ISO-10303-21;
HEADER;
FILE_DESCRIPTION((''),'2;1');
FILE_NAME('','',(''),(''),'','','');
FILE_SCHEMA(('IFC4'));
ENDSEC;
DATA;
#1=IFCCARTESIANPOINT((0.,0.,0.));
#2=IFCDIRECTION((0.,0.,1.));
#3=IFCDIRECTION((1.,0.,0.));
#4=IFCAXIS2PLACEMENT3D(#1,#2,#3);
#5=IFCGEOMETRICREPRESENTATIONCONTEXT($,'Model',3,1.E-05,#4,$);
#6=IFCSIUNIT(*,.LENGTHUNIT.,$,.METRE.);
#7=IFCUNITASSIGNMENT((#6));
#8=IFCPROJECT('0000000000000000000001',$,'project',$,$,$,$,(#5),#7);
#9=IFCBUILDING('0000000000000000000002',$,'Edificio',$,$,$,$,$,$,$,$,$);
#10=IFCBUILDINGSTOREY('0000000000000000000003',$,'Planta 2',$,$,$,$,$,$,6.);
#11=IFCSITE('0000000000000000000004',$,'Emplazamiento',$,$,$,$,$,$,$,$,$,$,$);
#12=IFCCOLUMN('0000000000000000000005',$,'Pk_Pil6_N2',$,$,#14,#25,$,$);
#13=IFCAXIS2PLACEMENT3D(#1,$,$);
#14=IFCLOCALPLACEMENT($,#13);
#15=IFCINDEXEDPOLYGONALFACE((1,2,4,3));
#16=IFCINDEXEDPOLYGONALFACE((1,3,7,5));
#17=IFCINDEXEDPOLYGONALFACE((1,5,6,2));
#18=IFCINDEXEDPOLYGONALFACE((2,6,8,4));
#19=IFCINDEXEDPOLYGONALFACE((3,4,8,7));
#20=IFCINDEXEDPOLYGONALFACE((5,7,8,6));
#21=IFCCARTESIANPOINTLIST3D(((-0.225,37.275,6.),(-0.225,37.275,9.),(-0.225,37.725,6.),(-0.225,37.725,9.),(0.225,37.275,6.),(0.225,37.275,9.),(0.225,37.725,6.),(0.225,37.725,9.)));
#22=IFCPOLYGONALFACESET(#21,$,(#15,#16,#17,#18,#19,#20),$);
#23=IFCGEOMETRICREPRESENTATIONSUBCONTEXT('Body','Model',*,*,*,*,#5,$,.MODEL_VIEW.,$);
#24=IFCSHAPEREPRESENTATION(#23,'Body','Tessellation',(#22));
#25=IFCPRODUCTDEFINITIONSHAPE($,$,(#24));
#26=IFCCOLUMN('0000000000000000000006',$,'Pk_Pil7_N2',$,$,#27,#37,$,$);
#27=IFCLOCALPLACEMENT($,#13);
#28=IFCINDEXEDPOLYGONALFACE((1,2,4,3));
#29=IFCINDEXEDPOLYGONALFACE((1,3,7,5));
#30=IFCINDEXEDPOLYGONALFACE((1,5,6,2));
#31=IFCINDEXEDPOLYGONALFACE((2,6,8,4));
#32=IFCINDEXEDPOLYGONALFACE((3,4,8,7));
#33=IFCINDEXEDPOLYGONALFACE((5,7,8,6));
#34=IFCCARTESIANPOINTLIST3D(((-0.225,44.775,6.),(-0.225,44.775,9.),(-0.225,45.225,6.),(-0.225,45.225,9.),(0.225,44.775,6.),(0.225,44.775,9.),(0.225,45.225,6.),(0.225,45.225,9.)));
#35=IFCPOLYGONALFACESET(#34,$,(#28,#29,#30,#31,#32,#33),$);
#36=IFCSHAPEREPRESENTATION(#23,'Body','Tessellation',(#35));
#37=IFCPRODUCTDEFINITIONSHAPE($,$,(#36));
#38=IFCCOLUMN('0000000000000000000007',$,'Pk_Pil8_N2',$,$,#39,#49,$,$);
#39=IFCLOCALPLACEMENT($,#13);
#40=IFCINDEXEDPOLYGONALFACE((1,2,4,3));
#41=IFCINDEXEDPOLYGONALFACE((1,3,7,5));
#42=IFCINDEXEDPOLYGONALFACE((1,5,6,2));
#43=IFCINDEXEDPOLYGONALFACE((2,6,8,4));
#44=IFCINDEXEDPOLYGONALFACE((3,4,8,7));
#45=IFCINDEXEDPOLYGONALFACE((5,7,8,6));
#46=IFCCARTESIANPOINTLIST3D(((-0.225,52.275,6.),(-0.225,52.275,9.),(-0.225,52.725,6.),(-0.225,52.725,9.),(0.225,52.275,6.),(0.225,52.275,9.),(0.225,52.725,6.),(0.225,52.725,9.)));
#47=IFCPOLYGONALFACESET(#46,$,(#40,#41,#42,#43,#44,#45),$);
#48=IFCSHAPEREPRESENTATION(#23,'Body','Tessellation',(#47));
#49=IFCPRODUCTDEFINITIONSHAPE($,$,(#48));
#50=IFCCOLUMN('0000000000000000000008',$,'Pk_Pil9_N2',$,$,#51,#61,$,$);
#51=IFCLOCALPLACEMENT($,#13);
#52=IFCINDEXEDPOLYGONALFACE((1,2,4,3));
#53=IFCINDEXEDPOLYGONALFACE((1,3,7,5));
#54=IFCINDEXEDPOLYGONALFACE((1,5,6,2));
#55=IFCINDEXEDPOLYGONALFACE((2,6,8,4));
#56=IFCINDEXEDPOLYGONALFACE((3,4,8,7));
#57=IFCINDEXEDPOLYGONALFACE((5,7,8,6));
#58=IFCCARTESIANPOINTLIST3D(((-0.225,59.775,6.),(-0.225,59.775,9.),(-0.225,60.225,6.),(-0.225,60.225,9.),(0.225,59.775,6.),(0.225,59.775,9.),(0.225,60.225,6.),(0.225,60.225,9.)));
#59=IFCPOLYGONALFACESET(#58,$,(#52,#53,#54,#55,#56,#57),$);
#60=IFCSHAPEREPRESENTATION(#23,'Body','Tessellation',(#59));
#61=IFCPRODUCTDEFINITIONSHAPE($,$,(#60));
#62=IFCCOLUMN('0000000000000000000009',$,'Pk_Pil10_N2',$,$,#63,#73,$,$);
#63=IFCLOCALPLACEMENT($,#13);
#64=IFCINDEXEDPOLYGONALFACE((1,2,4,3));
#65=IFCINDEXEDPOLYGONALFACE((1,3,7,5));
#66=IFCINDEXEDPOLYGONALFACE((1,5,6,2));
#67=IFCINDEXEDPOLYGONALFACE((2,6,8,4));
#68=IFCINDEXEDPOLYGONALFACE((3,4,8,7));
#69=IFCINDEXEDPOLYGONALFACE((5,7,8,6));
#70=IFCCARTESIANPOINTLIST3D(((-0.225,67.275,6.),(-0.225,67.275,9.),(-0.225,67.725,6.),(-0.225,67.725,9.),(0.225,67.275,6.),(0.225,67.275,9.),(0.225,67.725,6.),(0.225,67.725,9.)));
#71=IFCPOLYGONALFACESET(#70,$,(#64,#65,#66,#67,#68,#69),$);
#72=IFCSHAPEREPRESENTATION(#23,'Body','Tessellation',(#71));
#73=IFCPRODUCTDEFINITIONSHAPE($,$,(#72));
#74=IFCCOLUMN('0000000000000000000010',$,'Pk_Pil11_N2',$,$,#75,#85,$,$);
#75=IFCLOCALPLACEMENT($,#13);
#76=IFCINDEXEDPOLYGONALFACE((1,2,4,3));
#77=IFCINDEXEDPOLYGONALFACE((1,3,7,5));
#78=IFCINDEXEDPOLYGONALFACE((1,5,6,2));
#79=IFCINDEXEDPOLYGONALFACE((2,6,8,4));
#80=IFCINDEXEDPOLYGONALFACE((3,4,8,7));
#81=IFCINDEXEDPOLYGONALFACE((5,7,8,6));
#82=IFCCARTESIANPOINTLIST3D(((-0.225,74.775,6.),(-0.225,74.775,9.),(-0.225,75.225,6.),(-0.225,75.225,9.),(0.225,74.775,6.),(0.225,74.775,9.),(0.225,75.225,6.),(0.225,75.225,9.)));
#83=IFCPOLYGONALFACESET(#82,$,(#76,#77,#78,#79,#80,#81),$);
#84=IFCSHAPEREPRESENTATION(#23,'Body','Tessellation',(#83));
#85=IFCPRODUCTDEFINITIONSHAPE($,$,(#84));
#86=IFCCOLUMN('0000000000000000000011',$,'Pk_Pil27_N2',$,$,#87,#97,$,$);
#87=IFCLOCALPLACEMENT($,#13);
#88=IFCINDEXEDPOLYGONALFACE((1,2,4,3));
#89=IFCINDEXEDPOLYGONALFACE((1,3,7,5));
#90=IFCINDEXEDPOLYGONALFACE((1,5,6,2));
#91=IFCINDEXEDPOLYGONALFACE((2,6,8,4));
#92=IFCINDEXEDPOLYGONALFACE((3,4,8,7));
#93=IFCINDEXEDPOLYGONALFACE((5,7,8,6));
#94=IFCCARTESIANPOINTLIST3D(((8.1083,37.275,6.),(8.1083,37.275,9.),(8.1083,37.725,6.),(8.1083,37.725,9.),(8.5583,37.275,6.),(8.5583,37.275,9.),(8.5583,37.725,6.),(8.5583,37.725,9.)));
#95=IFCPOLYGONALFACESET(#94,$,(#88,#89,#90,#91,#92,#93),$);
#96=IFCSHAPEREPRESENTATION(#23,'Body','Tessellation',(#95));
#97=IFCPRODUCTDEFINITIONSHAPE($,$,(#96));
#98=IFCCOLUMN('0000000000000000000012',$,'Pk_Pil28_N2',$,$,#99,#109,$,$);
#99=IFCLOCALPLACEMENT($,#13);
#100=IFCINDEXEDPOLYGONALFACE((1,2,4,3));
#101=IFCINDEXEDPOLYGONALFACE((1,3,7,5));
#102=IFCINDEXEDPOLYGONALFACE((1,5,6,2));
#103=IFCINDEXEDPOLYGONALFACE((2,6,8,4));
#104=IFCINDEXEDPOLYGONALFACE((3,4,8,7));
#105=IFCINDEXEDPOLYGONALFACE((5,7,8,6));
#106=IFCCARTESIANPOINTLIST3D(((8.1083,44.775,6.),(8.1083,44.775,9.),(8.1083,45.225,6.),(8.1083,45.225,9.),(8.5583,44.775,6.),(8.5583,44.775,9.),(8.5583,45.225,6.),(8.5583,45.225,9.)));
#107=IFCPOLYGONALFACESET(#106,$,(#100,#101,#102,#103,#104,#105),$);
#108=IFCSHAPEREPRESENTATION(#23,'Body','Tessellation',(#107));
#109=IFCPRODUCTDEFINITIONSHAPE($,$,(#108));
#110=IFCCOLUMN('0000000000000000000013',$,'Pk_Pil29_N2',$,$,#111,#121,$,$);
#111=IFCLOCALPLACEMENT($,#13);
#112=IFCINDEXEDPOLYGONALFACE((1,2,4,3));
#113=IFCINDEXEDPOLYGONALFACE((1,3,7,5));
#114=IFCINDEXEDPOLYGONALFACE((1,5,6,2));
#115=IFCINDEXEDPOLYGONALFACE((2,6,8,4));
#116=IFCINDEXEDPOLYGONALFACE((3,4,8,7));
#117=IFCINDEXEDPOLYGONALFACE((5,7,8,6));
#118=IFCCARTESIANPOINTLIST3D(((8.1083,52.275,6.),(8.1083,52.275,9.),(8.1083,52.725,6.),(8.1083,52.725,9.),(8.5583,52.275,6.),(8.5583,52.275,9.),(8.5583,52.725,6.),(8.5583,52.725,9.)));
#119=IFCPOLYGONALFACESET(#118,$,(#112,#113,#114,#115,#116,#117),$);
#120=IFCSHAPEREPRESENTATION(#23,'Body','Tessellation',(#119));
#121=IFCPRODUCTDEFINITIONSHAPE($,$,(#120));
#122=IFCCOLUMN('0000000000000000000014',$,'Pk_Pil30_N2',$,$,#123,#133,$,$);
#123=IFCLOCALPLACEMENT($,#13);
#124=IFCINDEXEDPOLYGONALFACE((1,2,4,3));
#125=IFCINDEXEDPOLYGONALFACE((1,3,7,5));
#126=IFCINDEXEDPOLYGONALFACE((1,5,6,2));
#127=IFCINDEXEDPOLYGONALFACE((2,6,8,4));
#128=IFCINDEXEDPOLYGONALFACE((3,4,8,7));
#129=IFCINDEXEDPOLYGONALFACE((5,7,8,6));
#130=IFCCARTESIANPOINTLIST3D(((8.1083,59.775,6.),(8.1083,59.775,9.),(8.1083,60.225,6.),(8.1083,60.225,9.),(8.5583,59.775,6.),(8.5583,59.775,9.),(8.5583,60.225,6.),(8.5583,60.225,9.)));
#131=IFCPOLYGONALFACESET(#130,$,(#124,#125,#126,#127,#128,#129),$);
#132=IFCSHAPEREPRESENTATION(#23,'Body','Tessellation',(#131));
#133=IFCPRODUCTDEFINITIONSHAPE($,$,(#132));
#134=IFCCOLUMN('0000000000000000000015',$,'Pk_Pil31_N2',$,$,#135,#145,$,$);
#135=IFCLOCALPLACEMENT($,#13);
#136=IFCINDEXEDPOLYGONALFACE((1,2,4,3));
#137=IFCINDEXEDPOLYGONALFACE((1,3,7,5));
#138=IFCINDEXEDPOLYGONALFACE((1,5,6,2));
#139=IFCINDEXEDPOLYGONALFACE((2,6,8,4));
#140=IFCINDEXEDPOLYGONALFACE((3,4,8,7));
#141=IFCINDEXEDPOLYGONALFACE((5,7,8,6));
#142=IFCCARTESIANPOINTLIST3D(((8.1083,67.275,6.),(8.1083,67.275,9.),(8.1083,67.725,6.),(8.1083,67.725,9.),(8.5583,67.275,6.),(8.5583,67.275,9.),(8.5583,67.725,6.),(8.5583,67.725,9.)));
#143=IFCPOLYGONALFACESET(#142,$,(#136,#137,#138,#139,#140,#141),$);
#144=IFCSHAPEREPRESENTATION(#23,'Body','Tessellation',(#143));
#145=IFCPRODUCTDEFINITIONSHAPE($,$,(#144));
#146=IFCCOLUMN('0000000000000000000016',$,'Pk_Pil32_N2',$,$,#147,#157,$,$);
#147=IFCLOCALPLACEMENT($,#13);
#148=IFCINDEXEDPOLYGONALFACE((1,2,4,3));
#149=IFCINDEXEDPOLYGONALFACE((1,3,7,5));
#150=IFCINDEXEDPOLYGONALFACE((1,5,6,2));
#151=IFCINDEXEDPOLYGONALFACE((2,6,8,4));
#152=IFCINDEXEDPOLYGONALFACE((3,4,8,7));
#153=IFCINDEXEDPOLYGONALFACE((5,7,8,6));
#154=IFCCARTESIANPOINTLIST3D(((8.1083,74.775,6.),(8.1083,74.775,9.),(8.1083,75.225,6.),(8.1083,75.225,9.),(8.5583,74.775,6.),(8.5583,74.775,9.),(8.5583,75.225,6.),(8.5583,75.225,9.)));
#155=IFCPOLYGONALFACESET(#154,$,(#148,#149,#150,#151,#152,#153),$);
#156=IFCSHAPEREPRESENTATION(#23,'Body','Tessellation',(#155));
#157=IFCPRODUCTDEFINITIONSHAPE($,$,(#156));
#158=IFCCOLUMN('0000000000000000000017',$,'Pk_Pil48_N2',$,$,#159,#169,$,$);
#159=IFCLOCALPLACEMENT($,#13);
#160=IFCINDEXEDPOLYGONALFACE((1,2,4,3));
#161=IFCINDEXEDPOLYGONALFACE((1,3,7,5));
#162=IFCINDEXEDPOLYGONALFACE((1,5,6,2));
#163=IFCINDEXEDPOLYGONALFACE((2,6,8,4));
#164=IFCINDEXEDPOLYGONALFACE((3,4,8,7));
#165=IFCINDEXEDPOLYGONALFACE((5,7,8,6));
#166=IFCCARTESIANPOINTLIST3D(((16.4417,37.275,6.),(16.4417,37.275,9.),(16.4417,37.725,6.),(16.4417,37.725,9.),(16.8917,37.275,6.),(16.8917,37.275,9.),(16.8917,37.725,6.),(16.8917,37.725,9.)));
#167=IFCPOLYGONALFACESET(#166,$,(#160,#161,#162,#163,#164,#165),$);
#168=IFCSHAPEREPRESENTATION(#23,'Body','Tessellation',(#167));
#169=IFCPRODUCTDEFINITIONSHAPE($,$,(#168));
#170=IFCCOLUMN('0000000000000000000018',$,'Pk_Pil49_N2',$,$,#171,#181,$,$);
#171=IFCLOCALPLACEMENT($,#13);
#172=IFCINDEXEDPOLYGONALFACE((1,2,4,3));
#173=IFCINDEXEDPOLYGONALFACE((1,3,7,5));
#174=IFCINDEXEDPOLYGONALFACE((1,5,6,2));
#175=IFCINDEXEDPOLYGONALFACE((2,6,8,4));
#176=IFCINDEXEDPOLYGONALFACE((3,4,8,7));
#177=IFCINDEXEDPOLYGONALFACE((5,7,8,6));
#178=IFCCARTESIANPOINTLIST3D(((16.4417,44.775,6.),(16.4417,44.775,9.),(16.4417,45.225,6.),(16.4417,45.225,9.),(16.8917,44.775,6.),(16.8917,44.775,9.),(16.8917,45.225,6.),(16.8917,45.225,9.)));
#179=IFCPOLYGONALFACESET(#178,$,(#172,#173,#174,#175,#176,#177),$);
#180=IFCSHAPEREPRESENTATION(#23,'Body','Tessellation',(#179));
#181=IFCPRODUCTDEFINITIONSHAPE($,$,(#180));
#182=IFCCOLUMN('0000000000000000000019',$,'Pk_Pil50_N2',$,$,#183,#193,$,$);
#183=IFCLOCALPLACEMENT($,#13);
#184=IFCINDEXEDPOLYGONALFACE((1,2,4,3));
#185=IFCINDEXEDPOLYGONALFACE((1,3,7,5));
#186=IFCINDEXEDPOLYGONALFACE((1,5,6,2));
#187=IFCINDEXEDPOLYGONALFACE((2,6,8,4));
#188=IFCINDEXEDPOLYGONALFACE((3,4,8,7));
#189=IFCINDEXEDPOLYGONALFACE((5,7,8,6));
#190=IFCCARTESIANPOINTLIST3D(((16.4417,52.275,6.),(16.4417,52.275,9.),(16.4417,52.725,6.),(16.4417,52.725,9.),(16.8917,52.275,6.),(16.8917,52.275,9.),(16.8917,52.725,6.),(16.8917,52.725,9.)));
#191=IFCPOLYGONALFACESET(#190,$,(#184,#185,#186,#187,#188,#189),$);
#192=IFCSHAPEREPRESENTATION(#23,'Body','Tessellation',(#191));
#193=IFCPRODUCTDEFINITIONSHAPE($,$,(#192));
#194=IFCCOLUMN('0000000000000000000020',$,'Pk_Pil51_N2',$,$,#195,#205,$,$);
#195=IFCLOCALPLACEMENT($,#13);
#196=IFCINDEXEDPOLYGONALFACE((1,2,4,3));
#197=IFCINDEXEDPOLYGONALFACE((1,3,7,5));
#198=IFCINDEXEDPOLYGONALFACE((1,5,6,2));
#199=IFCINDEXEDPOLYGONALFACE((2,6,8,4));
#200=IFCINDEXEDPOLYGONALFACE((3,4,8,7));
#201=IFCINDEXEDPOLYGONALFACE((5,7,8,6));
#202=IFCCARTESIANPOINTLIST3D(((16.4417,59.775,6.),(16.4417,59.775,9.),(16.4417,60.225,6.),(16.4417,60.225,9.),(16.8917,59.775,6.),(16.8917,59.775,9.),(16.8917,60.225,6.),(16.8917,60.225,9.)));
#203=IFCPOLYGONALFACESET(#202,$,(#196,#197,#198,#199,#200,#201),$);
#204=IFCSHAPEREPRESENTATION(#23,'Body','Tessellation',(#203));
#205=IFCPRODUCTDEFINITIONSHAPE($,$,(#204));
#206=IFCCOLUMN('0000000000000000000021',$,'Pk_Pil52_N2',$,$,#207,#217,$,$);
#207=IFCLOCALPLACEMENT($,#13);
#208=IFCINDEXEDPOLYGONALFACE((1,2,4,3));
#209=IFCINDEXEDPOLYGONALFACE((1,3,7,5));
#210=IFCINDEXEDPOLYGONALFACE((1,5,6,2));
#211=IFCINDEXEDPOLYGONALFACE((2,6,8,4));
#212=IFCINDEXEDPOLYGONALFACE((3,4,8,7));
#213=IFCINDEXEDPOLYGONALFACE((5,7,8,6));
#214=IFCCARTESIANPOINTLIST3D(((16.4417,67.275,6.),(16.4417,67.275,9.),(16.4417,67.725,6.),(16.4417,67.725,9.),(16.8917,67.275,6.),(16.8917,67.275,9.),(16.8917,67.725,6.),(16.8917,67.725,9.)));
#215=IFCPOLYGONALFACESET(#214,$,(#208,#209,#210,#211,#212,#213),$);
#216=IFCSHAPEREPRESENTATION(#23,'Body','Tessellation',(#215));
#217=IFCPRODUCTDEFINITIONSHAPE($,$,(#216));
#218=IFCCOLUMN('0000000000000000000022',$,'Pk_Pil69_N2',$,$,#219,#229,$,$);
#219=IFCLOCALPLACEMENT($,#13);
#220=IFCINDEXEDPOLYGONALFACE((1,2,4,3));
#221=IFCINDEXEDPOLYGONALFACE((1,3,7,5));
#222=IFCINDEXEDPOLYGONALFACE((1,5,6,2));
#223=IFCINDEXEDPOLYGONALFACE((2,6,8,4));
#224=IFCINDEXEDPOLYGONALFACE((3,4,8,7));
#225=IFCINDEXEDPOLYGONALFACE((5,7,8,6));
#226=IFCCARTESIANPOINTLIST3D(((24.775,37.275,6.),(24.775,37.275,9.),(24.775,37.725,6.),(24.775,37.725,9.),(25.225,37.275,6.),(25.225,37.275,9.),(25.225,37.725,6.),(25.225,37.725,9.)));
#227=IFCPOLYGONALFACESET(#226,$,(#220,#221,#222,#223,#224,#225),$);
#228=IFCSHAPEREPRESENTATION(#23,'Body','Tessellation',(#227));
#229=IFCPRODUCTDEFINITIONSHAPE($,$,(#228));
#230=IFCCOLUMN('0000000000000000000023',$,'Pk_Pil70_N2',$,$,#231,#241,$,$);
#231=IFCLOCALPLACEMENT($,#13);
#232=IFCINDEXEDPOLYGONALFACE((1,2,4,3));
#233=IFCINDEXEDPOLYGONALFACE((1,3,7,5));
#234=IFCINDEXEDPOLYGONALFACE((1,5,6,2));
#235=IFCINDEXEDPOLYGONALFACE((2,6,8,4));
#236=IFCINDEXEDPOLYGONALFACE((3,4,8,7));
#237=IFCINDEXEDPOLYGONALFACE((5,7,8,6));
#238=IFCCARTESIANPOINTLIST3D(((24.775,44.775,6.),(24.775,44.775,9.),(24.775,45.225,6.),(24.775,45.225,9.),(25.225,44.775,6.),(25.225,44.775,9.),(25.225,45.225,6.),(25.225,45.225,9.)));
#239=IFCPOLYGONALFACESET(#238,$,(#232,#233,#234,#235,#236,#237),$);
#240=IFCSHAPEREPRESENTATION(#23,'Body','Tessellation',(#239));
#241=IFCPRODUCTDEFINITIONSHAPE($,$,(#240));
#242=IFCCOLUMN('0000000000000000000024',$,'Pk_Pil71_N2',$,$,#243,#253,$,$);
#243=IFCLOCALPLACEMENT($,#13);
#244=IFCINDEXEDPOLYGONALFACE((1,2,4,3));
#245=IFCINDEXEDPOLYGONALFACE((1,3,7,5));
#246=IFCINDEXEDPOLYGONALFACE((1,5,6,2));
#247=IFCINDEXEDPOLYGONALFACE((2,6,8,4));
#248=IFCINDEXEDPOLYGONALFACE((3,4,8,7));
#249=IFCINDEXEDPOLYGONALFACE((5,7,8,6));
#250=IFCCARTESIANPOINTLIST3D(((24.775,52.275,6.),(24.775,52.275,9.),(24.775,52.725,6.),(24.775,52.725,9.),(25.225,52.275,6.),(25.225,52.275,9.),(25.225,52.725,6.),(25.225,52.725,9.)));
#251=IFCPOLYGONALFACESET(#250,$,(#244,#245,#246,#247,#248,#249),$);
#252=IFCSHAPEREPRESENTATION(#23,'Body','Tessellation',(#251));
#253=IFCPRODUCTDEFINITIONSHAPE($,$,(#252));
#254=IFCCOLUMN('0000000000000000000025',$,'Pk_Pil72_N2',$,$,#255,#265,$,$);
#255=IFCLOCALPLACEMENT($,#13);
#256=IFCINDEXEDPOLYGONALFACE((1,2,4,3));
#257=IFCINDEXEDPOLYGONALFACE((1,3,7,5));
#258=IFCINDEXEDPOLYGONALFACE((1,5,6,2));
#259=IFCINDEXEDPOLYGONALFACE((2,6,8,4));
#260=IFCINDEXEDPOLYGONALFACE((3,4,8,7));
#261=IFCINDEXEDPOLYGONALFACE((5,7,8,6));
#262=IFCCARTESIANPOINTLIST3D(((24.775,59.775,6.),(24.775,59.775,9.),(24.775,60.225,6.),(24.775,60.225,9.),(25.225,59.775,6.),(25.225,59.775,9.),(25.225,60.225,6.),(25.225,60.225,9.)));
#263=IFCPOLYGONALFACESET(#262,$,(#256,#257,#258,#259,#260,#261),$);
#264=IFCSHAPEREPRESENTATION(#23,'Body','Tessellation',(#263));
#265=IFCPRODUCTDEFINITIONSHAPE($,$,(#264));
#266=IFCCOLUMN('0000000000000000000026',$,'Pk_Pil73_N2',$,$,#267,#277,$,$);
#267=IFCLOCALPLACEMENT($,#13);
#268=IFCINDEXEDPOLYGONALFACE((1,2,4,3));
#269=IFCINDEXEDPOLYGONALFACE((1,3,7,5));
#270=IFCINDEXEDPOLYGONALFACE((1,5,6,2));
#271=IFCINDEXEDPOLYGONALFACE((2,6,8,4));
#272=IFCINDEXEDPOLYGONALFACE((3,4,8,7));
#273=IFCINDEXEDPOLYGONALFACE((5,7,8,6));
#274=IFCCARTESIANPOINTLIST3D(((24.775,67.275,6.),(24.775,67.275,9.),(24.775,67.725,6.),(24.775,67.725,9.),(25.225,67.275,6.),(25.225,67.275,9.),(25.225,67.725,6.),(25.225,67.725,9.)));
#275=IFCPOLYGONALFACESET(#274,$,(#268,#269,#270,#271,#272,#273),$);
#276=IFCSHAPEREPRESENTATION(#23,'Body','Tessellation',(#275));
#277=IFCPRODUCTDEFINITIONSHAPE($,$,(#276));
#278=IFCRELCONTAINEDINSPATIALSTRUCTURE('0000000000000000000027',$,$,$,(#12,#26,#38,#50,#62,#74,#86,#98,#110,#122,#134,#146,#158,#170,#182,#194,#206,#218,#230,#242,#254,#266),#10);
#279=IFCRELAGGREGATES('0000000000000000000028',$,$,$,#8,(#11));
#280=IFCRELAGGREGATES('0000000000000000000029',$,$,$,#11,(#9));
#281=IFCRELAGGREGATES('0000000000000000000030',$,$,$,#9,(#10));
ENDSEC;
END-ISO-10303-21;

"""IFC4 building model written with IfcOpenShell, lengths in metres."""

from ifc_helpers import new_model, si_unit, frame, origin_with_axes, origin_2d, place, context, subcontext, project, spatial, rectangle, extrude, element, save


model = new_model("IFC4")

# Units and contexts
model_context = context("Model", 3, precision=1e-05, world=origin_with_axes())
body_context = subcontext(model_context, "Body", "Model", "MODEL_VIEW")
ifc_project = project(units=[si_unit("LENGTHUNIT", "METRE")], contexts=[model_context])

# Site, building, storey
site = spatial("IfcSite", under=ifc_project, Name="Emplazamiento")
building = spatial("IfcBuilding", under=site, Name="Edificio")
storey = spatial("IfcBuildingStorey", under=building, Name="Planta 2", Elevation=6.0)

# Columns
for number, where, z_axis, x_axis, name in (
    (1, (0.0, 37.5, 6.0), (0.0, 0.0, 1.0), (1.0, 0.0, 0.0), "Pk_Pil6_N2"),
    (2, (0.0, 45.0, 6.0), (0.0, 0.0, 1.0), (1.0, 0.0, 0.0), "Pk_Pil7_N2"),
    (3, (0.0, 52.5, 6.0), (0.0, 0.0, 1.0), (1.0, 0.0, 0.0), "Pk_Pil8_N2"),
    (4, (0.0, 60.0, 6.0), (0.0, 0.0, 1.0), (1.0, 0.0, 0.0), "Pk_Pil9_N2"),
    (5, (0.0, 67.5, 6.0), (0.0, 0.0, 1.0), (1.0, 0.0, 0.0), "Pk_Pil10_N2"),
    (6, (0.0, 75.0, 6.0), (0.0, 0.0, 1.0), (1.0, 0.0, 0.0), "Pk_Pil11_N2"),
    (7, (8.3333, 37.5, 6.0), (0.0, 0.0, 1.0), (1.0, 0.0, 0.0), "Pk_Pil27_N2"),
    (8, (8.3333, 45.0, 6.0), (0.0, 0.0, 1.0), (1.0, 0.0, 0.0), "Pk_Pil28_N2"),
    (9, (8.3333, 52.5, 6.0), (0.0, 0.0, 1.0), (1.0, 0.0, 0.0), "Pk_Pil29_N2"),
    (10, (8.3333, 60.0, 6.0), (0.0, 0.0, 1.0), (1.0, 0.0, 0.0), "Pk_Pil30_N2"),
    (11, (8.3333, 67.5, 6.0), (0.0, 0.0, 1.0), (1.0, 0.0, 0.0), "Pk_Pil31_N2"),
    (12, (8.3333, 75.0, 6.0), (0.0, 0.0, 1.0), (1.0, 0.0, 0.0), "Pk_Pil32_N2"),
    (13, (16.6667, 37.5, 6.0), (0.0, 0.0, 1.0), (1.0, 0.0, 0.0), "Pk_Pil48_N2"),
    (14, (16.6667, 45.0, 6.0), (0.0, 0.0, 1.0), (1.0, 0.0, 0.0), "Pk_Pil49_N2"),
    (15, (16.6667, 52.5, 6.0), (0.0, 0.0, 1.0), (1.0, 0.0, 0.0), "Pk_Pil50_N2"),
    (16, (16.6667, 60.0, 6.0), (0.0, 0.0, 1.0), (1.0, 0.0, 0.0), "Pk_Pil51_N2"),
    (17, (16.6667, 67.5, 6.0), (0.0, 0.0, 1.0), (1.0, 0.0, 0.0), "Pk_Pil52_N2"),
    (18, (25.0, 37.5, 6.0), (0.0, 0.0, 1.0), (1.0, 0.0, 0.0), "Pk_Pil69_N2"),
    (19, (25.0, 45.0, 6.0), (0.0, 0.0, 1.0), (1.0, 0.0, 0.0), "Pk_Pil70_N2"),
    (20, (25.0, 52.5, 6.0), (0.0, 0.0, 1.0), (1.0, 0.0, 0.0), "Pk_Pil71_N2"),
    (21, (25.0, 60.0, 6.0), (0.0, 0.0, 1.0), (1.0, 0.0, 0.0), "Pk_Pil72_N2"),
    (22, (25.0, 67.5, 6.0), (0.0, 0.0, 1.0), (1.0, 0.0, 0.0), "Pk_Pil73_N2"),
):
    element("IfcColumn", number, at=place(None, frame(where, z_axis=z_axis, x_axis=x_axis)), inside=storey, Name=name, context=body_context, shape_type="SweptSolid", body=[
        extrude(rectangle(XDim=0.45, YDim=0.45, at=origin_2d()), origin_with_axes(), (0.0, 0.0, 1.0), 3.0),
    ])

save(model, "model.ifc")
